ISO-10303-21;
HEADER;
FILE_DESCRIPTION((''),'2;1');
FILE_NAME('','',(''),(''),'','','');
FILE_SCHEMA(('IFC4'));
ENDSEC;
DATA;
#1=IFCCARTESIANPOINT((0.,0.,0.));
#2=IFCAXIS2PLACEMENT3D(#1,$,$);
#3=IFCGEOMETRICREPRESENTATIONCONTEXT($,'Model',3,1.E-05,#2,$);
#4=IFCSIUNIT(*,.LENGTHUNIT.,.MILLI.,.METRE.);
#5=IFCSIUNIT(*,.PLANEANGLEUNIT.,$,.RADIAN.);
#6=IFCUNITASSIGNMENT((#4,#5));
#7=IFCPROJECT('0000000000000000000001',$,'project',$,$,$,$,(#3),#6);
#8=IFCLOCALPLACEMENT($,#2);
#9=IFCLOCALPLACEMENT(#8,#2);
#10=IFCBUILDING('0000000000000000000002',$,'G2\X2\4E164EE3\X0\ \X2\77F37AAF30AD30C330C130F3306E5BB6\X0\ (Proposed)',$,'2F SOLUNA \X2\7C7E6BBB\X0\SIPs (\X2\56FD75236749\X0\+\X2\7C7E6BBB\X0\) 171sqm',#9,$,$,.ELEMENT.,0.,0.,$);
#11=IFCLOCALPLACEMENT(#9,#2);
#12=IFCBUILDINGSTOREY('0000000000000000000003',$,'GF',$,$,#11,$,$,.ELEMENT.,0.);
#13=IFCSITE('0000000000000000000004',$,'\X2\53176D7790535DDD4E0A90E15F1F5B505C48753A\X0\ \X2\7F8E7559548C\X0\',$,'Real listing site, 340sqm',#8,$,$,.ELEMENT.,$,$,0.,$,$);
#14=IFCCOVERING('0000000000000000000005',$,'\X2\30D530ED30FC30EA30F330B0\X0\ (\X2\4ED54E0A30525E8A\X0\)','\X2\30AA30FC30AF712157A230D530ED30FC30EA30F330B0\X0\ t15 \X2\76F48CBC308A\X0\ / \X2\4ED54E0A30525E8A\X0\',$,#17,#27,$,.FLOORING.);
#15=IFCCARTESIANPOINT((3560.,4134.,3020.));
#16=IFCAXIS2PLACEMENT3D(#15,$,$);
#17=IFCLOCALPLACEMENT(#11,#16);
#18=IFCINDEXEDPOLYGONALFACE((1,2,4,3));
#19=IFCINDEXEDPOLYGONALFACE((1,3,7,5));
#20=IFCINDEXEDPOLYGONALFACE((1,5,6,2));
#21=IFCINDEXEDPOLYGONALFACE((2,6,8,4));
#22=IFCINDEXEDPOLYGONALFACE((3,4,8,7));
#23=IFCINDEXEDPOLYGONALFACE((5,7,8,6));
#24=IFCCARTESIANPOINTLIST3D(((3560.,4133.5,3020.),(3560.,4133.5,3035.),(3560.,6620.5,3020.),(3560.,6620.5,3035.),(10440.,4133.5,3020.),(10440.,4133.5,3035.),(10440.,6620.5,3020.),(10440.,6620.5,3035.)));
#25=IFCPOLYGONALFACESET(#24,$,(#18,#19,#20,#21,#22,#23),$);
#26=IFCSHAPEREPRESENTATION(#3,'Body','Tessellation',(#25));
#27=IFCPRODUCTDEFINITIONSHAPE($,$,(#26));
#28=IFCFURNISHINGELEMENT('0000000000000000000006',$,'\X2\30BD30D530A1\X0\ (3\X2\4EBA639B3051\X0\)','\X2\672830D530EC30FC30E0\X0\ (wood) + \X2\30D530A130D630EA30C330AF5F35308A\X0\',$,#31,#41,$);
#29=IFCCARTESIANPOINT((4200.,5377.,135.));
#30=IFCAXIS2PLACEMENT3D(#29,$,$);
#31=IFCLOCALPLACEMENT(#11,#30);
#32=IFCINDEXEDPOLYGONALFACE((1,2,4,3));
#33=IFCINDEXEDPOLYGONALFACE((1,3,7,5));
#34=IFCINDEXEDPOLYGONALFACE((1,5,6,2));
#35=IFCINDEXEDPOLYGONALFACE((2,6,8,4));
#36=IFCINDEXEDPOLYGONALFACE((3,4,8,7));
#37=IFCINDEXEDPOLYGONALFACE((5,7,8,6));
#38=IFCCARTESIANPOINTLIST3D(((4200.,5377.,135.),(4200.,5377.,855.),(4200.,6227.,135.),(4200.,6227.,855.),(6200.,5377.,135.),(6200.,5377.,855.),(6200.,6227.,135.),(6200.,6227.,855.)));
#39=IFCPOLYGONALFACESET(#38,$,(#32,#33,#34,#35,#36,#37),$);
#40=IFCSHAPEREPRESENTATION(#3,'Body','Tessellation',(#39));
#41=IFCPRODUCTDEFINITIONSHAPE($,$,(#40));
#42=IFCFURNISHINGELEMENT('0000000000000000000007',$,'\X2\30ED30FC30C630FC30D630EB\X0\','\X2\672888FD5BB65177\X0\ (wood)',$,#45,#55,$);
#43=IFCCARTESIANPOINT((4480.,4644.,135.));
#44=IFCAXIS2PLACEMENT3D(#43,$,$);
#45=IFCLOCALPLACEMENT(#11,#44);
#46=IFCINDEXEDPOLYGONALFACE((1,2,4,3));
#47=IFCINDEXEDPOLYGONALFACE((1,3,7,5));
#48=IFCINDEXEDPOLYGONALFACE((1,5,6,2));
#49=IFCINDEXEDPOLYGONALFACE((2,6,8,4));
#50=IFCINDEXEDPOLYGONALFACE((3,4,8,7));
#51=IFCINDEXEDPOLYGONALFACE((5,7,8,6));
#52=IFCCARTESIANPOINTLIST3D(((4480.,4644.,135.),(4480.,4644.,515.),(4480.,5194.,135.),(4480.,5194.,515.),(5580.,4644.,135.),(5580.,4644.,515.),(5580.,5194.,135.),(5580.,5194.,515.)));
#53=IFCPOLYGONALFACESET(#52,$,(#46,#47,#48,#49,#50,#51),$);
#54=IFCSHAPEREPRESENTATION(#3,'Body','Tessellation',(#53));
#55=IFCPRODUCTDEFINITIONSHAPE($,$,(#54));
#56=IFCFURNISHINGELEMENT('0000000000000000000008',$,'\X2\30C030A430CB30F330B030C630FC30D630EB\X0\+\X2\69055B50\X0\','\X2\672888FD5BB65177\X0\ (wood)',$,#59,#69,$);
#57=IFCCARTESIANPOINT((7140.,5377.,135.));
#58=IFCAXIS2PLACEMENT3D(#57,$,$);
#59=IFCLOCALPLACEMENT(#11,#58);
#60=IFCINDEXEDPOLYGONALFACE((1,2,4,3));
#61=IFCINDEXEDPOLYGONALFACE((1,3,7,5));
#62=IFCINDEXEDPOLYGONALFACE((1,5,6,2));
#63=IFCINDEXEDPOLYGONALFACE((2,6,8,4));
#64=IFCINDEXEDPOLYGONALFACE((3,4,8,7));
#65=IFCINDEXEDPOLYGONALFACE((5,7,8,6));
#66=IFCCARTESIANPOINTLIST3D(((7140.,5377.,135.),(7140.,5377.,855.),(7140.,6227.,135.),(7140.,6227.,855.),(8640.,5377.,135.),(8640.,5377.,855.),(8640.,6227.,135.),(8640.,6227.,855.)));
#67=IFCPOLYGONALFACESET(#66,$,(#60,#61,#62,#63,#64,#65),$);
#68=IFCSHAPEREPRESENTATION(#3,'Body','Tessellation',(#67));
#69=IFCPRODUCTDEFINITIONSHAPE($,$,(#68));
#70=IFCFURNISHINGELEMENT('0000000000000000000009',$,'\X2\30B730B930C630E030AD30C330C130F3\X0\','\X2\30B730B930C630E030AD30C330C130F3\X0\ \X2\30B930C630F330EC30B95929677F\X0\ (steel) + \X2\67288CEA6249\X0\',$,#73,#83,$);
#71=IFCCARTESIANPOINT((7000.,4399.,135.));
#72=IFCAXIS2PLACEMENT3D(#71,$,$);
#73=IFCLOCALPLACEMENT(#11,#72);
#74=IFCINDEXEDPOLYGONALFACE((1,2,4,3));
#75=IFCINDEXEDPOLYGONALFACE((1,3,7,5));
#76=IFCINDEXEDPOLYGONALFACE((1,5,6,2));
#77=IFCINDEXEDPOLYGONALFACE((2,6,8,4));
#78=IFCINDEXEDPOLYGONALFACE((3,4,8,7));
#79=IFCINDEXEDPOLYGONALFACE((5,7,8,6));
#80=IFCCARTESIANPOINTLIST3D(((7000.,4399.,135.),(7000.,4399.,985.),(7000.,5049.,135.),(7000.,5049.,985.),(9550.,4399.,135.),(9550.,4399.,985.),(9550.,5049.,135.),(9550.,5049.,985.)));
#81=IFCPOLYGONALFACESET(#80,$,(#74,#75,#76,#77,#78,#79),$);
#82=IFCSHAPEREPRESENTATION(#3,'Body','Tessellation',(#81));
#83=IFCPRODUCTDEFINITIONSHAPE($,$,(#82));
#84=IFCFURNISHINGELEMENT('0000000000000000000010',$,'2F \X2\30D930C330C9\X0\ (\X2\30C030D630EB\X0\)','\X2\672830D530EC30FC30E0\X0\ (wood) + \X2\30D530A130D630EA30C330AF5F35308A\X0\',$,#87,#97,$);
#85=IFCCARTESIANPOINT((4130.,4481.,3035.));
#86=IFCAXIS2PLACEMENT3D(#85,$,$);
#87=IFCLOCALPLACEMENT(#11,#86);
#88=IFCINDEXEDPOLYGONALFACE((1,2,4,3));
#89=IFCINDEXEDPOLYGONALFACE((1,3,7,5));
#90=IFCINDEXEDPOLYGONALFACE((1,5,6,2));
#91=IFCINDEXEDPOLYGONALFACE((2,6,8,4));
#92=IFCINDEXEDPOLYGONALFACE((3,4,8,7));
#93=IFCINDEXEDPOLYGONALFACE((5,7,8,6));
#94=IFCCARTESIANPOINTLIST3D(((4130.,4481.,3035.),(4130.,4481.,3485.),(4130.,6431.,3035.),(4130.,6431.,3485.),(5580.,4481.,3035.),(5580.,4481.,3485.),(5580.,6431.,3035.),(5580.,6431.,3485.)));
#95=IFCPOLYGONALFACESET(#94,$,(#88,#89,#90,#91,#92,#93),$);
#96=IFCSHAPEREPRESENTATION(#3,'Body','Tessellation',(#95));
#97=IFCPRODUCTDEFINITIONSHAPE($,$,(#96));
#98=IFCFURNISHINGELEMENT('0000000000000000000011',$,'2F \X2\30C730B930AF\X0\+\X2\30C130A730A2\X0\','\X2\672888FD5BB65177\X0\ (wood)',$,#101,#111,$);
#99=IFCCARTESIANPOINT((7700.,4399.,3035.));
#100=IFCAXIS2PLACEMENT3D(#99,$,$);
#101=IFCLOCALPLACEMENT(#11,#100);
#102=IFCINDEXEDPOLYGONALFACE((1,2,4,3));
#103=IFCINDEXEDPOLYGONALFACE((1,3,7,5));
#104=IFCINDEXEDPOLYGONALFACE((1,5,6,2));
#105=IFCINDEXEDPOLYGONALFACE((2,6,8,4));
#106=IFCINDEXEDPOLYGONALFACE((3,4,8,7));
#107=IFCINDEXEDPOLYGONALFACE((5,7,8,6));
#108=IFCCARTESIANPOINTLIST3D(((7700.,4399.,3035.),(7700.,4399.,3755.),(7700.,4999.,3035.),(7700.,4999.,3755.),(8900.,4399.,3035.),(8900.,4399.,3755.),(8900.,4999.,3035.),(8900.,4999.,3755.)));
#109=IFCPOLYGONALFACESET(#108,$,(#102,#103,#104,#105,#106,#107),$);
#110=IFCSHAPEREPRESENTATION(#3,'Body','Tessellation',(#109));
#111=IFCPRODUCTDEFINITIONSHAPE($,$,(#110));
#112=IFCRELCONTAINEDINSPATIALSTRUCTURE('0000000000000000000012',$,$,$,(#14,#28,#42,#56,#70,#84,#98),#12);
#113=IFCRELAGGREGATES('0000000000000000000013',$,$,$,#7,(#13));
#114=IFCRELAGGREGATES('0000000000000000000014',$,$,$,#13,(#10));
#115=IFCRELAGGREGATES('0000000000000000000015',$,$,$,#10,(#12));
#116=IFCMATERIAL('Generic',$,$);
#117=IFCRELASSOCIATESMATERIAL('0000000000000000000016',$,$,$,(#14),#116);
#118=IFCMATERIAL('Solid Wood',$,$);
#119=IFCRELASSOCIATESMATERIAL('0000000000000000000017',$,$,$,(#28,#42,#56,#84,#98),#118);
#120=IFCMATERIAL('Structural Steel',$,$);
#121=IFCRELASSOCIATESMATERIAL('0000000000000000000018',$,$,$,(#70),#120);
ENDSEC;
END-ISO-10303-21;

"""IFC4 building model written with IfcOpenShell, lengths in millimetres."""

from ifc_helpers import new_model, si_unit, frame, frame_2d, origin, place, context, project, spatial, rectangle, extrude, material, element, save


model = new_model("IFC4")

# Units and contexts
model_context = context("Model", 3, precision=1e-05, world=origin())
ifc_project = project(units=[si_unit("LENGTHUNIT", "METRE", prefix="MILLI"), si_unit("PLANEANGLEUNIT", "RADIAN")], contexts=[model_context])

# Site, building, storey
site_placement = place(None, origin())
site = spatial("IfcSite", under=ifc_project, at=site_placement, Name="北海道川上郡弟子屈町 美留和", ObjectType="Real listing site, 340sqm", CompositionType="ELEMENT", RefElevation=0.0)
building_placement = place(site_placement, origin())
building = spatial("IfcBuilding", under=site, at=building_placement, Name="G2世代 石窯キッチンの家 (Proposed)", ObjectType="2F SOLUNA 籾殻SIPs (国産杉+籾殻) 171sqm", CompositionType="ELEMENT", ElevationOfRefHeight=0.0, ElevationOfTerrain=0.0)
storey_placement = place(building_placement, origin())
storey = spatial("IfcBuildingStorey", under=building, at=storey_placement, Name="GF", CompositionType="ELEMENT", Elevation=0.0)

# Shared definitions
ifc_material_1 = material(Name="Solid Wood")

# Shared definitions
ifc_material_2 = material(Name="Generic")

# Shared definitions
ifc_material_3 = material(Name="Structural Steel")

# Covering
covering_placement = place(storey_placement, frame((3560.0, 4134.0, 3020.0)))
element("IfcCovering", 1, at=covering_placement, inside=storey, material=ifc_material_2, Name="フローリング (仕上げ床)", Description="オーク無垢フローリング t15 直貼り / 仕上げ床", PredefinedType="FLOORING", context=model_context, shape_type="SweptSolid", body=[
    extrude(rectangle(XDim=6880.0, YDim=2487.0, at=frame_2d((3440.0, 1243.0))), frame((3560.0, 4134.0, 3020.0)), (0.0, 0.0, 1.0), 15.0),
])

# Furnishing elements
furnishing_1_placement = place(storey_placement, frame((4200.0, 5377.0, 135.0)))
element("IfcFurnishingElement", 2, at=furnishing_1_placement, inside=storey, material=ifc_material_1, Name="ソファ (3人掛け)", Description="木フレーム (wood) + ファブリック張り", context=model_context, shape_type="SweptSolid", body=[
    extrude(rectangle(XDim=2000.0, YDim=850.0, at=frame_2d((1000.0, 425.0))), frame((4200.0, 5377.0, 135.0)), (0.0, 0.0, 1.0), 720.0),
])
furnishing_2_placement = place(storey_placement, frame((4480.0, 4644.0, 135.0)))
element("IfcFurnishingElement", 3, at=furnishing_2_placement, inside=storey, material=ifc_material_1, Name="ローテーブル", Description="木製家具 (wood)", context=model_context, shape_type="SweptSolid", body=[
    extrude(rectangle(XDim=1100.0, YDim=550.0, at=frame_2d((550.0, 275.0))), frame((4480.0, 4644.0, 135.0)), (0.0, 0.0, 1.0), 380.0),
])
furnishing_3_placement = place(storey_placement, frame((7140.0, 5377.0, 135.0)))
element("IfcFurnishingElement", 4, at=furnishing_3_placement, inside=storey, material=ifc_material_1, Name="ダイニングテーブル+椅子", Description="木製家具 (wood)", context=model_context, shape_type="SweptSolid", body=[
    extrude(rectangle(XDim=1500.0, YDim=850.0, at=frame_2d((750.0, 425.0))), frame((7140.0, 5377.0, 135.0)), (0.0, 0.0, 1.0), 720.0),
])
furnishing_4_placement = place(storey_placement, frame((7000.0, 4399.0, 135.0)))
element("IfcFurnishingElement", 5, at=furnishing_4_placement, inside=storey, material=ifc_material_3, Name="システムキッチン", Description="システムキッチン ステンレス天板 (steel) + 木質扉", context=model_context, shape_type="SweptSolid", body=[
    extrude(rectangle(XDim=2550.0, YDim=650.0, at=frame_2d((1275.0, 325.0))), frame((7000.0, 4399.0, 135.0)), (0.0, 0.0, 1.0), 850.0),
])
furnishing_5_placement = place(storey_placement, frame((4130.0, 4481.0, 3035.0)))
element("IfcFurnishingElement", 6, at=furnishing_5_placement, inside=storey, material=ifc_material_1, Name="2F ベッド (ダブル)", Description="木フレーム (wood) + ファブリック張り", context=model_context, shape_type="SweptSolid", body=[
    extrude(rectangle(XDim=1450.0, YDim=1950.0, at=frame_2d((725.0, 975.0))), frame((4130.0, 4481.0, 3035.0)), (0.0, 0.0, 1.0), 450.0),
])
furnishing_6_placement = place(storey_placement, frame((7700.0, 4399.0, 3035.0)))
element("IfcFurnishingElement", 7, at=furnishing_6_placement, inside=storey, material=ifc_material_1, Name="2F デスク+チェア", Description="木製家具 (wood)", context=model_context, shape_type="SweptSolid", body=[
    extrude(rectangle(XDim=1200.0, YDim=600.0, at=frame_2d((600.0, 300.0))), frame((7700.0, 4399.0, 3035.0)), (0.0, 0.0, 1.0), 720.0),
])

save(model, "model.ifc")
